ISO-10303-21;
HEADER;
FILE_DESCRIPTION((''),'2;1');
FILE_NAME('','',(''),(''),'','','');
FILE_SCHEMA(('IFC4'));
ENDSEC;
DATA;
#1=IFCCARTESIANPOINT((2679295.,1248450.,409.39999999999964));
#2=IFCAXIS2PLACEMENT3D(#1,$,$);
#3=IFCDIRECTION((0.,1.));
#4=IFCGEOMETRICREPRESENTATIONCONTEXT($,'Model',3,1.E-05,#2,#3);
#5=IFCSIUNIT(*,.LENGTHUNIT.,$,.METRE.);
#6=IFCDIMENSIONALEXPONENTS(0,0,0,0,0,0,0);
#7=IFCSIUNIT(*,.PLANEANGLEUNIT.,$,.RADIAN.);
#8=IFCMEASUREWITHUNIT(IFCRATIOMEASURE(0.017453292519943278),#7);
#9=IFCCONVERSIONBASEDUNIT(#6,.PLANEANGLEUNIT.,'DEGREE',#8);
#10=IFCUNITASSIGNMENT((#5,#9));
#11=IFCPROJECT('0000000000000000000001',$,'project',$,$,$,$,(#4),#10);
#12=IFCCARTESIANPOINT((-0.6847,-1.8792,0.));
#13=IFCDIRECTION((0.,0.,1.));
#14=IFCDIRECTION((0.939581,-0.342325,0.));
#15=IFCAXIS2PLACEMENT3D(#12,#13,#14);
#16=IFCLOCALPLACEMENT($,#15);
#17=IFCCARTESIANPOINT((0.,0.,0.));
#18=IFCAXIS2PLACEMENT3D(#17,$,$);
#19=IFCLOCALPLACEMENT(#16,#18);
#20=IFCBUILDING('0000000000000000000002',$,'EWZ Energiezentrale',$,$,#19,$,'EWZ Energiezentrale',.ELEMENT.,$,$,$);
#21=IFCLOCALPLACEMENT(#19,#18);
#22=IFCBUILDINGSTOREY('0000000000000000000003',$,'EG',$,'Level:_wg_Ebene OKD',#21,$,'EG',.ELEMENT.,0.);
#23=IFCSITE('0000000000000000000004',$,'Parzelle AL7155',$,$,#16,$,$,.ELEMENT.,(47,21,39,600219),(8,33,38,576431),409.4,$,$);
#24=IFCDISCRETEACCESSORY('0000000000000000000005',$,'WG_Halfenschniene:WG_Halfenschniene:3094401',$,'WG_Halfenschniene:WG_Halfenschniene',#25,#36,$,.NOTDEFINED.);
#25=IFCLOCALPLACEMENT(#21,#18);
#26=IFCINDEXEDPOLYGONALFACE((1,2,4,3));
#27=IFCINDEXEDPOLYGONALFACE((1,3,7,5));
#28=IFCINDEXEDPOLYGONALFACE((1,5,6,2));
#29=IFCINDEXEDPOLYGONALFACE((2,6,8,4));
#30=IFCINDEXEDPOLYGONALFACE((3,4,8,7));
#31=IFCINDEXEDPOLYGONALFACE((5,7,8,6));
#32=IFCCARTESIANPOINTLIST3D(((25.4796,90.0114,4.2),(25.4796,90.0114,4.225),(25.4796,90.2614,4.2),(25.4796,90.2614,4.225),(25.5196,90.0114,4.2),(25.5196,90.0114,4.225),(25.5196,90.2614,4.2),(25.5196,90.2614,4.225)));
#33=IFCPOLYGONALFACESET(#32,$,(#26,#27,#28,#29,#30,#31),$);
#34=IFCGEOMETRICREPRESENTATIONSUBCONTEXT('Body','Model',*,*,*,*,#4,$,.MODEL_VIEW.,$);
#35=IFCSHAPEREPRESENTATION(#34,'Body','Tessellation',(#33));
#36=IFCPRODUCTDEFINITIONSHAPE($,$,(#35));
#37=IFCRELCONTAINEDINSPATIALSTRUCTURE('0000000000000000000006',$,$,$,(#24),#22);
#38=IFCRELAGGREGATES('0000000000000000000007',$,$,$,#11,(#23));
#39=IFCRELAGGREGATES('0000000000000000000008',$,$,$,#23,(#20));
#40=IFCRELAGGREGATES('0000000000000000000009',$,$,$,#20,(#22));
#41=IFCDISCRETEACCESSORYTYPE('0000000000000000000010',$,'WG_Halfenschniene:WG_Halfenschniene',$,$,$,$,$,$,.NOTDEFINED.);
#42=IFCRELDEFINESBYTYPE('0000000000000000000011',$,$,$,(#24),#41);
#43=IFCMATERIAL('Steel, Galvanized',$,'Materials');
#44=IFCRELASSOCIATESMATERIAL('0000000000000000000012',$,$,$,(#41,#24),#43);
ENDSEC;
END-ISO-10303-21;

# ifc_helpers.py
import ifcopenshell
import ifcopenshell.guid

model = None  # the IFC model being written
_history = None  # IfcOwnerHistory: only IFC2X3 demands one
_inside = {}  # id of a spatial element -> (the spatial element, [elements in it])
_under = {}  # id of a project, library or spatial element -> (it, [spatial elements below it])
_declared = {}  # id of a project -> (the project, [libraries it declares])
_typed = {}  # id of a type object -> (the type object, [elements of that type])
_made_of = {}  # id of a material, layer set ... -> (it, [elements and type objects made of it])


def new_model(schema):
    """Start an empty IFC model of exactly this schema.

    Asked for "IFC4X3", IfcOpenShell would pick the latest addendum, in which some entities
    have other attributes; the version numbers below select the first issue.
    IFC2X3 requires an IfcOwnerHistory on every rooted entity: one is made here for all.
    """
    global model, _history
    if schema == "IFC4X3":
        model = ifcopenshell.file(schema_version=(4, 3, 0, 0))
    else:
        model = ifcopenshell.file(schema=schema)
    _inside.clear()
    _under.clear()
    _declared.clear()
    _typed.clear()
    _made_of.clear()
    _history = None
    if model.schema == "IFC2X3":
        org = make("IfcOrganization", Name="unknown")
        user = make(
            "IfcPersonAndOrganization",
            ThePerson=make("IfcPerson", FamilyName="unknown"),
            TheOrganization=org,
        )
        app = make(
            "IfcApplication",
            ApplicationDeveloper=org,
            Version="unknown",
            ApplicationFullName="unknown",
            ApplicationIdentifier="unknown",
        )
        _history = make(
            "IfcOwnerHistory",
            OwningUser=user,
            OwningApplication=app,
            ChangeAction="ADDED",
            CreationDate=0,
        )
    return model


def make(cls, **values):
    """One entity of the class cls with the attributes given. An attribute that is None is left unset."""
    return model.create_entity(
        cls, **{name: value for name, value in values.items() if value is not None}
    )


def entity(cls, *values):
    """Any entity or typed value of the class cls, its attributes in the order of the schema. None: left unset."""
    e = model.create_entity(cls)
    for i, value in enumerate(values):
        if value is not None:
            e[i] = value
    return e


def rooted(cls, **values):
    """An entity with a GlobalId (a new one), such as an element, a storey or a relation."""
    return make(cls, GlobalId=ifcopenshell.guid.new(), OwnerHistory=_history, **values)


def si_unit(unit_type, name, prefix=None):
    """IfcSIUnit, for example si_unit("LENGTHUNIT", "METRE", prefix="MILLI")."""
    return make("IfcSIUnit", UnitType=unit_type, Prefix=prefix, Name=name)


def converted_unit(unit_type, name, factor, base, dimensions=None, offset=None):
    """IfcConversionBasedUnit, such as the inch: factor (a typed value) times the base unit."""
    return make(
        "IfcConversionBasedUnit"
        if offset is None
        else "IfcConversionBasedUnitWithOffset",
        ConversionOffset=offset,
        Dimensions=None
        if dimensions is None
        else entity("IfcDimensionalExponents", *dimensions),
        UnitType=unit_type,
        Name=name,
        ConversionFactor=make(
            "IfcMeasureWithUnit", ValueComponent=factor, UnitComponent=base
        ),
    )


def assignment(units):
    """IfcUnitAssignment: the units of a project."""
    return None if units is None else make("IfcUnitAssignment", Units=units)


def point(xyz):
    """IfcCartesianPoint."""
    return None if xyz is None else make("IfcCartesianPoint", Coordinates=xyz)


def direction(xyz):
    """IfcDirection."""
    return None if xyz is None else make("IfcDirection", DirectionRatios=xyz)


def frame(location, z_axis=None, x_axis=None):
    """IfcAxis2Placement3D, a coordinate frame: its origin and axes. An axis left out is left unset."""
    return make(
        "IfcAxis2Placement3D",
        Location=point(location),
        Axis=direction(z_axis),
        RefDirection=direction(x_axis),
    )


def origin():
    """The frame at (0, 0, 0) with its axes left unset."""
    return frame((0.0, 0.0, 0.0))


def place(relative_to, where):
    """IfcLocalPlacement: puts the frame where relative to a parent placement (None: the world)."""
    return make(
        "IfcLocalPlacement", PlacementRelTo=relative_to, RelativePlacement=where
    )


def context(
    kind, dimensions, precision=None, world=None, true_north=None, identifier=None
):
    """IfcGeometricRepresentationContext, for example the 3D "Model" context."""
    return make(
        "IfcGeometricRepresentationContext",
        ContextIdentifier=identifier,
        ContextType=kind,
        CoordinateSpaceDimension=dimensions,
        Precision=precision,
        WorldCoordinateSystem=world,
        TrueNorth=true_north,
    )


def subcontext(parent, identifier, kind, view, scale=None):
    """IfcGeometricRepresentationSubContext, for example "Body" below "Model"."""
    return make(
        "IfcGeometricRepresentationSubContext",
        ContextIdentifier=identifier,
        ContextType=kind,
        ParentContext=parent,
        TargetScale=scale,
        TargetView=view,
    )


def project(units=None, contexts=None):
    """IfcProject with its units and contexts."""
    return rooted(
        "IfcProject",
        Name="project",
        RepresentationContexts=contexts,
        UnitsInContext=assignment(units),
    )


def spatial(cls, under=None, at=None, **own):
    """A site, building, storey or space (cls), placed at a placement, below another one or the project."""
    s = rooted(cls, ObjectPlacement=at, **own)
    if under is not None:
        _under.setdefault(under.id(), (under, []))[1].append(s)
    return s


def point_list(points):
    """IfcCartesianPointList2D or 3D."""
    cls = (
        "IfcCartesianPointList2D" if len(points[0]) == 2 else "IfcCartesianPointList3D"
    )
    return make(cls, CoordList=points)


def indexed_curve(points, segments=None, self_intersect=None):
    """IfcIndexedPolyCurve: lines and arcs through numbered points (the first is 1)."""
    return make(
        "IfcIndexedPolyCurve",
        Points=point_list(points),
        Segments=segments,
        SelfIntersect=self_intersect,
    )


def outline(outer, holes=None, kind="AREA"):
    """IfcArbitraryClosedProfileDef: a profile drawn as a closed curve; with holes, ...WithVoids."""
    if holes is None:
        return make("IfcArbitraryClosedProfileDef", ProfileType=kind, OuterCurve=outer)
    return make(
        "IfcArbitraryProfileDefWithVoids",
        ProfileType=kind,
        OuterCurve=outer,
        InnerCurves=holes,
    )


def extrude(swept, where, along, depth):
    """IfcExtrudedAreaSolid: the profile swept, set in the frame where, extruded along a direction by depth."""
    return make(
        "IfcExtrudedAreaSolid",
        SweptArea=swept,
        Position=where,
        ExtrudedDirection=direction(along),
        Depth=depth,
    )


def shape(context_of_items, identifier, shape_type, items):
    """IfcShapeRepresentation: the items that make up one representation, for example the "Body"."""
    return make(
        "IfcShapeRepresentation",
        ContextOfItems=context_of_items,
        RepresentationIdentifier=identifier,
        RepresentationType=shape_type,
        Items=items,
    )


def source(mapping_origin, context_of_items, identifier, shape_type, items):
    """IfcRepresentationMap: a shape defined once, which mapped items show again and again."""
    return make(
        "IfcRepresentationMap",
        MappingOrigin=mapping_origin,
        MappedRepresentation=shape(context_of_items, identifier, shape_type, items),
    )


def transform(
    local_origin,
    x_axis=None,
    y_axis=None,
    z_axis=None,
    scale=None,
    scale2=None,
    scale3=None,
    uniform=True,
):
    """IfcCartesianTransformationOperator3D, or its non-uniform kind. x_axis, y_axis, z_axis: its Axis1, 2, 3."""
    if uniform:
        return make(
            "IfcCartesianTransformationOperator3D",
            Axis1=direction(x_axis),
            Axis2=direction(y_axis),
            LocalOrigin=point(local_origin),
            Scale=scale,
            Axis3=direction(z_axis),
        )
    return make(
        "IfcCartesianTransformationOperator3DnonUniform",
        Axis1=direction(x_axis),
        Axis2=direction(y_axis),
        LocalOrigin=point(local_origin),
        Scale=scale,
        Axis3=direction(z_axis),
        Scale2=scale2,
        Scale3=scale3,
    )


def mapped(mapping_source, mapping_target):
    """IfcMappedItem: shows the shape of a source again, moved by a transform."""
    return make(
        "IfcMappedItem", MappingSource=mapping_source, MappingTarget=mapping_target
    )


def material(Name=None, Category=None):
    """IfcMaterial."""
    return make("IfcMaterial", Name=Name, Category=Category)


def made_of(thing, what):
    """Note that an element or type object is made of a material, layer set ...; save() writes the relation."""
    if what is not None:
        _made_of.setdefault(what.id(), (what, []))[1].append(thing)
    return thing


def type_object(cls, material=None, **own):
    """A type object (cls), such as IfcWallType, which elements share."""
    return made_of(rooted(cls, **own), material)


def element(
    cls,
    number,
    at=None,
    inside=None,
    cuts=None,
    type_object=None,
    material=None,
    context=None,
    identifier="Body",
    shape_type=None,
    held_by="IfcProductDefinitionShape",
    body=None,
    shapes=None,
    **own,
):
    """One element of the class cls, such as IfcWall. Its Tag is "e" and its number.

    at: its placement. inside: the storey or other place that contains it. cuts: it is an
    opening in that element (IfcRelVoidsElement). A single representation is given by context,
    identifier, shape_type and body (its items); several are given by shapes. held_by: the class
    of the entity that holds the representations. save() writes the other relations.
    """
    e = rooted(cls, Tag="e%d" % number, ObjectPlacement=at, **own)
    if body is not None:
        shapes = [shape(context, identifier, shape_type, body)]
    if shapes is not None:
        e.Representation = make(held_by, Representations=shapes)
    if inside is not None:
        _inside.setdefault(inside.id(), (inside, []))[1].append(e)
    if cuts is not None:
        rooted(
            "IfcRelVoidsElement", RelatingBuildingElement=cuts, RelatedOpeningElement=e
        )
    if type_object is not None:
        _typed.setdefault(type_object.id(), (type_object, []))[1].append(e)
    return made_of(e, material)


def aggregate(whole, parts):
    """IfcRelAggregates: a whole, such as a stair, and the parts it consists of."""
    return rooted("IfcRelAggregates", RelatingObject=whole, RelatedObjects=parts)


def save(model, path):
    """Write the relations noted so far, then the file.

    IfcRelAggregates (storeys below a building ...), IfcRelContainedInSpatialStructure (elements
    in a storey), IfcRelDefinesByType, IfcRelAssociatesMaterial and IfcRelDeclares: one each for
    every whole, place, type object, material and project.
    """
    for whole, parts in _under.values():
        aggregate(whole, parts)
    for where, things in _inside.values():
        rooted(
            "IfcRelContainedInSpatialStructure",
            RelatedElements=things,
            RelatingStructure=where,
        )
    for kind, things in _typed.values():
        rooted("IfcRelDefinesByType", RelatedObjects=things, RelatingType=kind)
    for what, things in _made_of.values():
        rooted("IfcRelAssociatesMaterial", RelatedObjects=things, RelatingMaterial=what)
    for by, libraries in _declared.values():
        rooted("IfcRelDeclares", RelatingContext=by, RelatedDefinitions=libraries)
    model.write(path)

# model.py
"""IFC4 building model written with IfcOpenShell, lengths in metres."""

from ifc_helpers import new_model, entity, si_unit, converted_unit, direction, frame, origin, place, context, subcontext, project, spatial, indexed_curve, outline, extrude, source, transform, mapped, material, type_object, element, save


model = new_model("IFC4")

# Units and contexts
model_context = context("Model", 3, precision=1e-05, world=frame((2679295.0, 1248450.0, 409.39999999999964)), true_north=direction((0.0, 1.0)))
body_context = subcontext(model_context, "Body", "Model", "MODEL_VIEW")
ifc_project = project(units=[si_unit("LENGTHUNIT", "METRE"), converted_unit("PLANEANGLEUNIT", "DEGREE", entity("IfcRatioMeasure", 0.017453292519943278), si_unit("PLANEANGLEUNIT", "RADIAN"), dimensions=[0, 0, 0, 0, 0, 0, 0])], contexts=[model_context])

# Site, building, storey
site_placement = place(None, frame((-0.6847, -1.8792, 0.0), z_axis=(0.0, 0.0, 1.0), x_axis=(0.939581, -0.342325, 0.0)))
site = spatial("IfcSite", under=ifc_project, at=site_placement, Name="Parzelle AL7155", CompositionType="ELEMENT", RefLatitude=(47, 21, 39, 600219), RefLongitude=(8, 33, 38, 576431), RefElevation=409.4)
building_placement = place(site_placement, origin())
building = spatial("IfcBuilding", under=site, at=building_placement, Name="EWZ Energiezentrale", LongName="EWZ Energiezentrale", CompositionType="ELEMENT")
storey_placement = place(building_placement, origin())
storey = spatial("IfcBuildingStorey", under=building, at=storey_placement, Name="EG", ObjectType="Level:_wg_Ebene OKD", LongName="EG", CompositionType="ELEMENT", Elevation=0.0)

# Discrete accessory
ifc_material = material(Name="Steel, Galvanized", Category="Materials")
discrete_accessory_type = type_object("IfcDiscreteAccessoryType", Name="WG_Halfenschniene:WG_Halfenschniene", PredefinedType="NOTDEFINED", material=ifc_material)
shared_shape = source(origin(), body_context, "Body", "SweptSolid", [
    extrude(outline(indexed_curve([(-0.125, -0.02), (0.125, -0.02), (0.125, 0.02), (-0.125, 0.02), (-0.125, -0.02)], self_intersect=False)), frame((0.125, 0.0, -0.0125)), (0.0, 0.0, 1.0), 0.025),
])
for number, where, z_axis, x_axis, name in (
    (1, (25.4996, 90.0114, 4.2125), (0.0, 0.0, -1.0), (0.0, 1.0, 0.0), "WG_Halfenschniene:WG_Halfenschniene:3094401"),
):
    element("IfcDiscreteAccessory", number, at=place(storey_placement, frame(where, z_axis=z_axis, x_axis=x_axis)), inside=storey, type_object=discrete_accessory_type, material=ifc_material, Name=name, ObjectType="WG_Halfenschniene:WG_Halfenschniene", PredefinedType="NOTDEFINED", context=body_context, shape_type="MappedRepresentation", body=[
        mapped(shared_shape, transform((0.0, 0.0, 0.0), scale=1.0)),
    ])

save(model, "model.ifc")
